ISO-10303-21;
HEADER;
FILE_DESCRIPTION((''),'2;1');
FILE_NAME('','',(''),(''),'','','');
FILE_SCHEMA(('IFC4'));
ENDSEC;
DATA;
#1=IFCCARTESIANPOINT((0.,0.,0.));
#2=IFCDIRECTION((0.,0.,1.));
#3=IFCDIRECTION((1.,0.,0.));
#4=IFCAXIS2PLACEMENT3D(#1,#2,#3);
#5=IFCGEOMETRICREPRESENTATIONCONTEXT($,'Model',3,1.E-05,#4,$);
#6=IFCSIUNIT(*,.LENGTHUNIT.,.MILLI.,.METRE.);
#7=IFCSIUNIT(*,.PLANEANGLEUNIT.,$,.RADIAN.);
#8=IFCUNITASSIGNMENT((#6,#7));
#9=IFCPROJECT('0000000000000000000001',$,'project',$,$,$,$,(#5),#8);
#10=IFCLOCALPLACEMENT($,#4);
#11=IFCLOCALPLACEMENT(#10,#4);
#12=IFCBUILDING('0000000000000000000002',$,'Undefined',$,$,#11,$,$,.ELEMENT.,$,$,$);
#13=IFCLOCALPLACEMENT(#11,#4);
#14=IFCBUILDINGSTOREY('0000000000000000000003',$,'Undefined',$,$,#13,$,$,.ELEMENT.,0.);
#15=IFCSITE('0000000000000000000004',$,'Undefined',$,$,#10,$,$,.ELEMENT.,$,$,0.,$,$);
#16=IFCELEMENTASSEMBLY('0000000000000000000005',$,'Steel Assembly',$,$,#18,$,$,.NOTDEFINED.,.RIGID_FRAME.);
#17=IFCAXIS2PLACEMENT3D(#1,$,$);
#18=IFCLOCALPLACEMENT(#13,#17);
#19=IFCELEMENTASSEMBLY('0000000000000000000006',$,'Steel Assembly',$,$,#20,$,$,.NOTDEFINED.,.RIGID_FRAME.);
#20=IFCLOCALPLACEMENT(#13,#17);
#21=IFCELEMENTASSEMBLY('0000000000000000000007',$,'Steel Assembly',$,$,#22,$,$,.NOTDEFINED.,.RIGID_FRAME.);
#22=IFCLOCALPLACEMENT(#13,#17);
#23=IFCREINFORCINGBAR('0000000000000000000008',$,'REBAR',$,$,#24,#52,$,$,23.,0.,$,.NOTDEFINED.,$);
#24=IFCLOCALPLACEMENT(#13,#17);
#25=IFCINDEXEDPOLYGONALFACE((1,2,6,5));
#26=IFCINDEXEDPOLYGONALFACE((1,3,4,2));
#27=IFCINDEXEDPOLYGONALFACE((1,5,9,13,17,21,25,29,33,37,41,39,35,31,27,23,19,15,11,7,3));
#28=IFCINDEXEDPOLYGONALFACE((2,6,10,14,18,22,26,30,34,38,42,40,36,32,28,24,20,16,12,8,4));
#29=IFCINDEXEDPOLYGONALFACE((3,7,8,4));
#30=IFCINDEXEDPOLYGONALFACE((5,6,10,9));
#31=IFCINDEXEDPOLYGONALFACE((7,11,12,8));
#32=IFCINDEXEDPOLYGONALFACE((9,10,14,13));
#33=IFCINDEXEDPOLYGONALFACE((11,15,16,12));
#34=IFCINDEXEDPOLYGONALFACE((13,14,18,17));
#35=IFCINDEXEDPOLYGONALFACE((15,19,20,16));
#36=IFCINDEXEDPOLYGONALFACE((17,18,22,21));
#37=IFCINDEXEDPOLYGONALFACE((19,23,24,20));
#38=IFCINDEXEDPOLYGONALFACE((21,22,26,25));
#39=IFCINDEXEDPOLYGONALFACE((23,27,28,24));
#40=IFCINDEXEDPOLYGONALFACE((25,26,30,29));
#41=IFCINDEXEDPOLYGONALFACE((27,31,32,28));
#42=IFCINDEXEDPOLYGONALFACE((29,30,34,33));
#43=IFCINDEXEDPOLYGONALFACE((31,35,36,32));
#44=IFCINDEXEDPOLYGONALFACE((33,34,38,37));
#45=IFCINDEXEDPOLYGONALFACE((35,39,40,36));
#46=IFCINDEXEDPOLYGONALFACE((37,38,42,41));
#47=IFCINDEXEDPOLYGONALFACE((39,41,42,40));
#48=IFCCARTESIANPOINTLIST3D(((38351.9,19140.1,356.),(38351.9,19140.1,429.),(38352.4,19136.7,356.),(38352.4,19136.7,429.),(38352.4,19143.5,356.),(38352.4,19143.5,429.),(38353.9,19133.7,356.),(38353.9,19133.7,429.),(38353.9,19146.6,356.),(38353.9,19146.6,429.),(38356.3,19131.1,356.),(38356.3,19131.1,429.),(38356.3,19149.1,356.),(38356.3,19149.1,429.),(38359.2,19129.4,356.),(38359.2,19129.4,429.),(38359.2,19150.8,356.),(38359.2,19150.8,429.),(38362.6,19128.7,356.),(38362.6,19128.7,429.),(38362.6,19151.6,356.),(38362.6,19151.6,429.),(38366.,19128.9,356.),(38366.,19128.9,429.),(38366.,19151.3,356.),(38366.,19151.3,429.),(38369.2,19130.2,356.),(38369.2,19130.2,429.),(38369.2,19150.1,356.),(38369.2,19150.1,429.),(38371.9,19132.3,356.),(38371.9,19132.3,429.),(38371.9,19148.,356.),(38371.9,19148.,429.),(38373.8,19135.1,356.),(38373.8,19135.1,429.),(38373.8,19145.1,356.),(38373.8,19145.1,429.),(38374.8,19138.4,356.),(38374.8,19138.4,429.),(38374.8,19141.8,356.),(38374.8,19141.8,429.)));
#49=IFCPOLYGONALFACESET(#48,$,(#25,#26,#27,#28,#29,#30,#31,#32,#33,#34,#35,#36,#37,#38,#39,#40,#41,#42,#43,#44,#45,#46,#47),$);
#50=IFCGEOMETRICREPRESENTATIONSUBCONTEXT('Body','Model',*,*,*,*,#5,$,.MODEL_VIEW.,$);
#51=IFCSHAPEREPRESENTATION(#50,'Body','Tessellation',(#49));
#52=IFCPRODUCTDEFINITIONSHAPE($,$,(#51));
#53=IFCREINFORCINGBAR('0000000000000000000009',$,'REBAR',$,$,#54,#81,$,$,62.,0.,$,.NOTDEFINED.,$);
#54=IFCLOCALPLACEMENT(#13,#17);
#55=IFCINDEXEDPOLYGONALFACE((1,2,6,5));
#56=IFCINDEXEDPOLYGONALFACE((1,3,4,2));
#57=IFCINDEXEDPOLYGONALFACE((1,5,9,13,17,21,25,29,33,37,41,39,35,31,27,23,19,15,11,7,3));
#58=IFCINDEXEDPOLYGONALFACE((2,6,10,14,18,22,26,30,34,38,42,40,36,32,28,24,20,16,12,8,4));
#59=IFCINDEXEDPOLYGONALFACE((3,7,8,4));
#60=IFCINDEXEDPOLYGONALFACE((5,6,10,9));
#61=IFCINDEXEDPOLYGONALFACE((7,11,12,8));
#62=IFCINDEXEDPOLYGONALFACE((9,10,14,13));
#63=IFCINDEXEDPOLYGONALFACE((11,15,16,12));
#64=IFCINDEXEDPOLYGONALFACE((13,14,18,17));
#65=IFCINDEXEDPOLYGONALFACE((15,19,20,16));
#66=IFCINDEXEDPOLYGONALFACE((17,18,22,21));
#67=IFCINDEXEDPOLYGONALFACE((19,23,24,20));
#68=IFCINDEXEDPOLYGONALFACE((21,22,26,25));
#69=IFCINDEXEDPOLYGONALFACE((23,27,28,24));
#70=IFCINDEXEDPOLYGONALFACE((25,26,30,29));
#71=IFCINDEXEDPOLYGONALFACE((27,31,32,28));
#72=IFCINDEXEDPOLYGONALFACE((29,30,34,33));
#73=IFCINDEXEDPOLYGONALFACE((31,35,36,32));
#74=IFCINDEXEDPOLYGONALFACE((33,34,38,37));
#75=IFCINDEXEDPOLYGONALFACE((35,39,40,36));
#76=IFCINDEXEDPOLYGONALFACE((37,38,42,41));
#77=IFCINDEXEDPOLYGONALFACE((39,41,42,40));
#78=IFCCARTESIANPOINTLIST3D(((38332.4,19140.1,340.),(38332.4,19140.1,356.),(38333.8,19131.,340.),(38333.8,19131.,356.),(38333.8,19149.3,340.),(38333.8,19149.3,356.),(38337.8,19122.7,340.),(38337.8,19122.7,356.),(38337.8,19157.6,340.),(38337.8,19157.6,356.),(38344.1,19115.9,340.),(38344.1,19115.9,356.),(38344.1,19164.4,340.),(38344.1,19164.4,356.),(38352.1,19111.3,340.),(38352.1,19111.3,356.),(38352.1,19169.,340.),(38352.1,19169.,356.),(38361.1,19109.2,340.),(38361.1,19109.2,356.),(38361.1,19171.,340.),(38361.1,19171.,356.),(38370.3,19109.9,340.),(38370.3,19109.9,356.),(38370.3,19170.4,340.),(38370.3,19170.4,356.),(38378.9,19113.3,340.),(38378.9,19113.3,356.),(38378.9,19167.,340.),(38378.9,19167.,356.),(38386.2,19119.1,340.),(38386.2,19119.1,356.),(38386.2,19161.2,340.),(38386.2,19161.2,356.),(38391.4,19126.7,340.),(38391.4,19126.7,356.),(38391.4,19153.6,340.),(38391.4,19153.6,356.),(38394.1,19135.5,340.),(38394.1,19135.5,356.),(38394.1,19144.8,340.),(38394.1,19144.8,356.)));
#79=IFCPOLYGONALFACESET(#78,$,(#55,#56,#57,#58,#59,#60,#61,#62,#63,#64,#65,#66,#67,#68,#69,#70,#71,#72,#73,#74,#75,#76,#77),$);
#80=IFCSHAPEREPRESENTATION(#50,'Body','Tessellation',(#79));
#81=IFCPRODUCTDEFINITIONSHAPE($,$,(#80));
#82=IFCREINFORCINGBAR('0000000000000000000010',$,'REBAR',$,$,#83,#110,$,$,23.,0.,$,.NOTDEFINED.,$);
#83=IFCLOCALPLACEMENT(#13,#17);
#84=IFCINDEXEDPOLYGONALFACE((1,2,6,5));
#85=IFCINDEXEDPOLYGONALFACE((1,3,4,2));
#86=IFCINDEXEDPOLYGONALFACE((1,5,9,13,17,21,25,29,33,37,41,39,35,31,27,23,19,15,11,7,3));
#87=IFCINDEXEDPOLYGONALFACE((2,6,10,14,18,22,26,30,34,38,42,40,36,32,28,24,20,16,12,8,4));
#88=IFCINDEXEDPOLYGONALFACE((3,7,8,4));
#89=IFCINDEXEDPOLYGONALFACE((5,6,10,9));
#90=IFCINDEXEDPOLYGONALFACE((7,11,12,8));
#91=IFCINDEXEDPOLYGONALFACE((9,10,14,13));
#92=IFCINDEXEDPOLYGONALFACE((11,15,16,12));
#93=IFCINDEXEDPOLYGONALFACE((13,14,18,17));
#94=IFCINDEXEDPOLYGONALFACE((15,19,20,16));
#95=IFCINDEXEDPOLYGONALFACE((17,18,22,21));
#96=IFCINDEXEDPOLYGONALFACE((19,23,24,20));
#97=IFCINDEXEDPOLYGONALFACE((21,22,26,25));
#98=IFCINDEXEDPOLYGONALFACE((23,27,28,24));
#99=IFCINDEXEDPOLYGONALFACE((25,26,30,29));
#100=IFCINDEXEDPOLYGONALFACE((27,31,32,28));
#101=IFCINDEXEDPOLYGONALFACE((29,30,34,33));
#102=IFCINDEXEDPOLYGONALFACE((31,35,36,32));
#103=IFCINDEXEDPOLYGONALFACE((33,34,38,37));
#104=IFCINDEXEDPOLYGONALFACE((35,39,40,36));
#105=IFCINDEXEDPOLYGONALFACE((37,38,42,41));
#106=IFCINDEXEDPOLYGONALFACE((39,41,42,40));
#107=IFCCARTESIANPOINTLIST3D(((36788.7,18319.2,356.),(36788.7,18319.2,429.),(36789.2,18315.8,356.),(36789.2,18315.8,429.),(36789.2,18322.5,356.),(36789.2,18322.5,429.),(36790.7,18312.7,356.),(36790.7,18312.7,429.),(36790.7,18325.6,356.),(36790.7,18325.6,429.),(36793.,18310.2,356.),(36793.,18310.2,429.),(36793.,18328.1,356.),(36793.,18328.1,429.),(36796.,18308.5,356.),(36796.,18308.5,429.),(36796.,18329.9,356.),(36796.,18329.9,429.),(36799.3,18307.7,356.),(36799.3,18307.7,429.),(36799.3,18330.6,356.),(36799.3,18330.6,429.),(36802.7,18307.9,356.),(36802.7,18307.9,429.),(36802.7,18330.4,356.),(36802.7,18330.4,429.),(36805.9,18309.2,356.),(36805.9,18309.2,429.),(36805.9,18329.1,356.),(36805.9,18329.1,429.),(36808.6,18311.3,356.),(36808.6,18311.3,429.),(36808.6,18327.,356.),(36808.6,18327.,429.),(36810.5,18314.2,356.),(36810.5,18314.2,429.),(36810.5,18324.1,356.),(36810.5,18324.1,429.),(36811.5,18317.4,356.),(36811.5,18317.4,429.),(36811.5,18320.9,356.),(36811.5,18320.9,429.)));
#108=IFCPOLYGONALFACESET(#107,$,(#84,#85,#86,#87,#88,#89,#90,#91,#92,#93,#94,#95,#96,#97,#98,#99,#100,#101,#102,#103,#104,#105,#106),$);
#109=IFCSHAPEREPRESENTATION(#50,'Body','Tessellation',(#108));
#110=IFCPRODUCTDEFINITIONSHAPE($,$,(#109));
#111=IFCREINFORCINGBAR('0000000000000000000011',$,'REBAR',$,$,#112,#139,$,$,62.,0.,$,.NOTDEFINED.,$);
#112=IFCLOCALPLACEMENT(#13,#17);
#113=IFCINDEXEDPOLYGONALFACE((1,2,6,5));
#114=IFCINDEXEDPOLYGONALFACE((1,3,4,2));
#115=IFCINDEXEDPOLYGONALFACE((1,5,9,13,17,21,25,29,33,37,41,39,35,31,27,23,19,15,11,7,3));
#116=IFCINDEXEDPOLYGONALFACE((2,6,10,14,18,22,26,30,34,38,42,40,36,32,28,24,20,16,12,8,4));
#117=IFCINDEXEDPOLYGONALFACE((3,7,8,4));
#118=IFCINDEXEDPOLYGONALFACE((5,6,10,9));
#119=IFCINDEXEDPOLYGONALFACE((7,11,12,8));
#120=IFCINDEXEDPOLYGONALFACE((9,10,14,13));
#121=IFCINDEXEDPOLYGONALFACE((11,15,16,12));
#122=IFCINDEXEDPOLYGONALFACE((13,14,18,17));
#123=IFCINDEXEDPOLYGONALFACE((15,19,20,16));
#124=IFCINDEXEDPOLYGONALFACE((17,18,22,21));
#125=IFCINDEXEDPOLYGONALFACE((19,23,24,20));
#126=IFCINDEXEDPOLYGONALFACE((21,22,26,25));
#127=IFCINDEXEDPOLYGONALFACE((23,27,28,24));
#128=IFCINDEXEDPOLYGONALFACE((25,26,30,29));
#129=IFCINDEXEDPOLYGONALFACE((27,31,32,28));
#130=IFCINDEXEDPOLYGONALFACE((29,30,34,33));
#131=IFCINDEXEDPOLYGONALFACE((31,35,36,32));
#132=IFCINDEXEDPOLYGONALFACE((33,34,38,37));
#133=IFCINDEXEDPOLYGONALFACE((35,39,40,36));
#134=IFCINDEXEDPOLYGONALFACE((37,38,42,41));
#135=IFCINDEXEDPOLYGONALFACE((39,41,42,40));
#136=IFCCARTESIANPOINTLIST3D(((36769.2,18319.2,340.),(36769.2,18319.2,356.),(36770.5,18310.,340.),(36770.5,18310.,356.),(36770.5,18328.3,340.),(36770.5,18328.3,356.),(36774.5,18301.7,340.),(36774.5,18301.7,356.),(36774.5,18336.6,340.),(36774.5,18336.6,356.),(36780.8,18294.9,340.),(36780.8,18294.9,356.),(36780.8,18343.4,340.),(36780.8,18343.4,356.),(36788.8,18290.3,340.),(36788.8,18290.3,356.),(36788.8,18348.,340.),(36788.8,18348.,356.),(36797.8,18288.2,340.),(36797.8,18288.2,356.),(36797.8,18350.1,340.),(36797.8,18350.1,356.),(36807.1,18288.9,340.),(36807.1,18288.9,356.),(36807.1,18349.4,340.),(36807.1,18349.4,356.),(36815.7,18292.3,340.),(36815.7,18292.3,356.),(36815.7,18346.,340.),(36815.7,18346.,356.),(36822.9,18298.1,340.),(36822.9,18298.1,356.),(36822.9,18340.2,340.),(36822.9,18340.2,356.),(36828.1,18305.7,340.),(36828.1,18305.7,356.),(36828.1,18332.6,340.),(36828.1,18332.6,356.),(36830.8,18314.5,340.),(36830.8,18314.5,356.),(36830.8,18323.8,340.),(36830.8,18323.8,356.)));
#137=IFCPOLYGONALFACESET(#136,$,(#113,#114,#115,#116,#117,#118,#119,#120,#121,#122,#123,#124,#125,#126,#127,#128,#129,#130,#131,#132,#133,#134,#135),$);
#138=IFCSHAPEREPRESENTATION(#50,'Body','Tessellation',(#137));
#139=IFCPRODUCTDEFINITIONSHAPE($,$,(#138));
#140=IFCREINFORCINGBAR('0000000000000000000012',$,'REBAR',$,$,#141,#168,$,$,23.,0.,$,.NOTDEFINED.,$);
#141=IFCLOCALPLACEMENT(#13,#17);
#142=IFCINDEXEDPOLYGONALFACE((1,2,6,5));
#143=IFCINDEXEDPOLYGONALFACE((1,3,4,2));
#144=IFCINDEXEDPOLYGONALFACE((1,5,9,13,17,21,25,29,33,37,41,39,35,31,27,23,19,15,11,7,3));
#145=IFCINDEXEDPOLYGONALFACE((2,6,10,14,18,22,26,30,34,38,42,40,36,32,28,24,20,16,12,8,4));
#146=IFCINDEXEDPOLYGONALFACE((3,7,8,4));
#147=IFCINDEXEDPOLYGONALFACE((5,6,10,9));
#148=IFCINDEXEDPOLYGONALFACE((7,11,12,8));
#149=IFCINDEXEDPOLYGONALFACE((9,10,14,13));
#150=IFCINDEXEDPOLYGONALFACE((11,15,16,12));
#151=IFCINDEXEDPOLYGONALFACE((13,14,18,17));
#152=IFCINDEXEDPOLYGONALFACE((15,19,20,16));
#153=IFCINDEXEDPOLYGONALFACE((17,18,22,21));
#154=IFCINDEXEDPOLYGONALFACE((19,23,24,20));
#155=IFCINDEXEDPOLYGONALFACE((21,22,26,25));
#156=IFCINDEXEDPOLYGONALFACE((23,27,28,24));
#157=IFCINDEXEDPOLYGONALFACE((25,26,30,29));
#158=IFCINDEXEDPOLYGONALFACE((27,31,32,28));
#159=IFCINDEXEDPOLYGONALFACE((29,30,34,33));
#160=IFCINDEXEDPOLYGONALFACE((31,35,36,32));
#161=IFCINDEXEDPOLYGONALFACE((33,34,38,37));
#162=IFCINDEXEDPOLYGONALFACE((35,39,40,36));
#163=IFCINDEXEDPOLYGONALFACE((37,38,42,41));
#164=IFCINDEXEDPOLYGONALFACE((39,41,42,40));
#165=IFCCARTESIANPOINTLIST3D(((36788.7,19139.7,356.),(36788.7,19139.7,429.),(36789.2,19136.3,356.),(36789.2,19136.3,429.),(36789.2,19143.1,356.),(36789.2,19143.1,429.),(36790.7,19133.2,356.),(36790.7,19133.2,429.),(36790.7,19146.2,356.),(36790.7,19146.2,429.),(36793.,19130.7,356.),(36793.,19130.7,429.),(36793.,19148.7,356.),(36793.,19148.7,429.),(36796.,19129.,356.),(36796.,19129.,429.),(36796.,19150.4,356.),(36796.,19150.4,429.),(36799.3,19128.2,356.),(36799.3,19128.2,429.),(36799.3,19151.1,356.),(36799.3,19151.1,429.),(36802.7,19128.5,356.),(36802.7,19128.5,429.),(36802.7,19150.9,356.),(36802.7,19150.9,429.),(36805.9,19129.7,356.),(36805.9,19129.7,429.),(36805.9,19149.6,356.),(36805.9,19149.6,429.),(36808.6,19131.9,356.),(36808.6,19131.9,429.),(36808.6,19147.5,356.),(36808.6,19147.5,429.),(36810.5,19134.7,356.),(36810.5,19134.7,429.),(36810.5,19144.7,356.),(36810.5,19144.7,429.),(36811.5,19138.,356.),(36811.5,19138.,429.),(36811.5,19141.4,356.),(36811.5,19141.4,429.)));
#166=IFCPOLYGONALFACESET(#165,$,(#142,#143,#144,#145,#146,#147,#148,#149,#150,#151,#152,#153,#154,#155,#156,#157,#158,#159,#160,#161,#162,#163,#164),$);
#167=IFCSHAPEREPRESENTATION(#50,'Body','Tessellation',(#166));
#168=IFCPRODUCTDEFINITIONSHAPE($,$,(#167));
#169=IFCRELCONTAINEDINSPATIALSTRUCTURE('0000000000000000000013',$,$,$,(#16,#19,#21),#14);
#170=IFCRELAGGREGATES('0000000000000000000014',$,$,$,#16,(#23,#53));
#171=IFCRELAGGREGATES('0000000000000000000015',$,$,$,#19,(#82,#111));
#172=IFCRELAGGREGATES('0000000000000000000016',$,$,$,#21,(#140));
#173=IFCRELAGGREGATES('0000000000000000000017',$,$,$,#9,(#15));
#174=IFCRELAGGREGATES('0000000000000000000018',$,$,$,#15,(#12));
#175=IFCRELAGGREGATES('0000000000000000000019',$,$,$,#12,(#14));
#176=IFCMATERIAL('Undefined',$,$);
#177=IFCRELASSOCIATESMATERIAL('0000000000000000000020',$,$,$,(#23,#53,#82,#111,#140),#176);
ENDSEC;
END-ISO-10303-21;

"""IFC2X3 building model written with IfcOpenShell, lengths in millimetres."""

from ifc_helpers import new_model, entity, si_unit, frame, origin_with_axes, place, context, subcontext, project, spatial, source, transform, mapped, material, element, aggregate, save


model = new_model("IFC2X3")

# Units and contexts
model_context = context("Model", 3, precision=1e-05, world=origin_with_axes())
body_context = subcontext(model_context, "Body", "Model", "MODEL_VIEW")
ifc_project = project(units=[si_unit("LENGTHUNIT", "METRE", prefix="MILLI"), si_unit("PLANEANGLEUNIT", "RADIAN")], contexts=[model_context])

# Site, building, storey
site_placement = place(None, origin_with_axes())
site = spatial("IfcSite", under=ifc_project, at=site_placement, Name="Undefined", CompositionType="ELEMENT", RefElevation=0.0)
building_placement = place(site_placement, origin_with_axes())
building = spatial("IfcBuilding", under=site, at=building_placement, Name="Undefined", CompositionType="ELEMENT")
storey_placement = place(building_placement, origin_with_axes())
storey = spatial("IfcBuildingStorey", under=building, at=storey_placement, Name="Undefined", CompositionType="ELEMENT", Elevation=0.0)

# Element assemblies
assembly_1_placement = place(storey_placement, origin_with_axes())
assembly_1 = element("IfcElementAssembly", 1, at=assembly_1_placement, inside=storey, Name="Steel Assembly", AssemblyPlace="NOTDEFINED", PredefinedType="RIGID_FRAME")
assembly_2_placement = place(storey_placement, origin_with_axes())
assembly_2 = element("IfcElementAssembly", 2, at=assembly_2_placement, inside=storey, Name="Steel Assembly", AssemblyPlace="NOTDEFINED", PredefinedType="RIGID_FRAME")
assembly_3_placement = place(storey_placement, origin_with_axes())
assembly_3 = element("IfcElementAssembly", 3, at=assembly_3_placement, inside=storey, Name="Steel Assembly", AssemblyPlace="NOTDEFINED", PredefinedType="RIGID_FRAME")

# Reinforcing bars
ifc_material_1 = material(Name="Undefined")
shared_shape_1 = source(origin_with_axes(), body_context, "Body", "AdvancedSweptSolid", [
    entity("IfcSweptDiskSolid", entity("IfcTrimmedCurve", entity("IfcLine", entity("IfcCartesianPoint", [0.0, 0.0, 0.0]), entity("IfcVector", entity("IfcDirection", [1.0, 0.0, 0.0]), 1.0)), [entity("IfcParameterValue", 0.0)], [entity("IfcParameterValue", 73.0)], True, "PARAMETER"), 11.5, None, 0.0, 73.0),
])
reinforcing_bar_1_placement = place(assembly_1_placement, frame((38363.4, 19140.1, 429.0), z_axis=(-1.0, 0.000005, 0.0), x_axis=(0.0, 0.0, -1.0)))
reinforcing_bar_1 = element("IfcReinforcingBar", 4, at=reinforcing_bar_1_placement, material=ifc_material_1, Name="REBAR", BarRole="NOTDEFINED", CrossSectionArea=0.0, NominalDiameter=23.0, context=body_context, shape_type="MappedRepresentation", body=[
    mapped(shared_shape_1, transform((0.0, 0.0, 0.0))),
])
shared_shape_2 = source(origin_with_axes(), body_context, "Body", "AdvancedSweptSolid", [
    entity("IfcSweptDiskSolid", entity("IfcTrimmedCurve", entity("IfcLine", entity("IfcCartesianPoint", [0.0, 0.0, 0.0]), entity("IfcVector", entity("IfcDirection", [1.0, 0.0, 0.0]), 1.0)), [entity("IfcParameterValue", 0.0)], [entity("IfcParameterValue", 16.0)], True, "PARAMETER"), 31.0, None, 0.0, 16.0),
])
reinforcing_bar_2_placement = place(assembly_1_placement, frame((38363.4, 19140.1, 353.0), z_axis=(-1.0, 0.000005, 0.0), x_axis=(0.0, 0.0, -1.0)))
reinforcing_bar_2 = element("IfcReinforcingBar", 5, at=reinforcing_bar_2_placement, material=ifc_material_1, Name="REBAR", BarRole="NOTDEFINED", CrossSectionArea=0.0, NominalDiameter=62.0, context=body_context, shape_type="MappedRepresentation", body=[
    mapped(shared_shape_2, transform((-3.0, 0.0, 0.0))),
])
aggregate(assembly_1, [reinforcing_bar_1, reinforcing_bar_2])
shared_shape_3 = source(origin_with_axes(), body_context, "Body", "AdvancedSweptSolid", [
    entity("IfcSweptDiskSolid", entity("IfcTrimmedCurve", entity("IfcLine", entity("IfcCartesianPoint", [0.0, 0.0, 0.0]), entity("IfcVector", entity("IfcDirection", [1.0, 0.0, 0.0]), 1.0)), [entity("IfcParameterValue", 0.0)], [entity("IfcParameterValue", 73.0)], True, "PARAMETER"), 11.5, None, 0.0, 73.0),
])
reinforcing_bar_3_placement = place(assembly_2_placement, frame((36800.2, 18319.2, 429.0), z_axis=(-1.0, 0.000005, 0.0), x_axis=(0.0, 0.0, -1.0)))
reinforcing_bar_3 = element("IfcReinforcingBar", 6, at=reinforcing_bar_3_placement, material=ifc_material_1, Name="REBAR", BarRole="NOTDEFINED", CrossSectionArea=0.0, NominalDiameter=23.0, context=body_context, shape_type="MappedRepresentation", body=[
    mapped(shared_shape_3, transform((0.0, 0.0, 0.0))),
])
shared_shape_4 = source(origin_with_axes(), body_context, "Body", "AdvancedSweptSolid", [
    entity("IfcSweptDiskSolid", entity("IfcTrimmedCurve", entity("IfcLine", entity("IfcCartesianPoint", [0.0, 0.0, 0.0]), entity("IfcVector", entity("IfcDirection", [1.0, 0.0, 0.0]), 1.0)), [entity("IfcParameterValue", 0.0)], [entity("IfcParameterValue", 16.0)], True, "PARAMETER"), 31.0, None, 0.0, 16.0),
])
reinforcing_bar_4_placement = place(assembly_2_placement, frame((36800.2, 18319.2, 353.0), z_axis=(-1.0, 0.000005, 0.0), x_axis=(0.0, 0.0, -1.0)))
reinforcing_bar_4 = element("IfcReinforcingBar", 7, at=reinforcing_bar_4_placement, material=ifc_material_1, Name="REBAR", BarRole="NOTDEFINED", CrossSectionArea=0.0, NominalDiameter=62.0, context=body_context, shape_type="MappedRepresentation", body=[
    mapped(shared_shape_4, transform((-3.0, 0.0, 0.0))),
])
aggregate(assembly_2, [reinforcing_bar_3, reinforcing_bar_4])
shared_shape_5 = source(origin_with_axes(), body_context, "Body", "AdvancedSweptSolid", [
    entity("IfcSweptDiskSolid", entity("IfcTrimmedCurve", entity("IfcLine", entity("IfcCartesianPoint", [0.0, 0.0, 0.0]), entity("IfcVector", entity("IfcDirection", [1.0, 0.0, 0.0]), 1.0)), [entity("IfcParameterValue", 0.0)], [entity("IfcParameterValue", 73.0)], True, "PARAMETER"), 11.5, None, 0.0, 73.0),
])
reinforcing_bar_5_placement = place(assembly_3_placement, frame((36800.2, 19139.7, 429.0), z_axis=(-1.0, 0.000005, 0.0), x_axis=(0.0, 0.0, -1.0)))
reinforcing_bar_5 = element("IfcReinforcingBar", 8, at=reinforcing_bar_5_placement, material=ifc_material_1, Name="REBAR", BarRole="NOTDEFINED", CrossSectionArea=0.0, NominalDiameter=23.0, context=body_context, shape_type="MappedRepresentation", body=[
    mapped(shared_shape_5, transform((0.0, 0.0, 0.0))),
])
aggregate(assembly_3, [reinforcing_bar_5])

save(model, "model.ifc")
